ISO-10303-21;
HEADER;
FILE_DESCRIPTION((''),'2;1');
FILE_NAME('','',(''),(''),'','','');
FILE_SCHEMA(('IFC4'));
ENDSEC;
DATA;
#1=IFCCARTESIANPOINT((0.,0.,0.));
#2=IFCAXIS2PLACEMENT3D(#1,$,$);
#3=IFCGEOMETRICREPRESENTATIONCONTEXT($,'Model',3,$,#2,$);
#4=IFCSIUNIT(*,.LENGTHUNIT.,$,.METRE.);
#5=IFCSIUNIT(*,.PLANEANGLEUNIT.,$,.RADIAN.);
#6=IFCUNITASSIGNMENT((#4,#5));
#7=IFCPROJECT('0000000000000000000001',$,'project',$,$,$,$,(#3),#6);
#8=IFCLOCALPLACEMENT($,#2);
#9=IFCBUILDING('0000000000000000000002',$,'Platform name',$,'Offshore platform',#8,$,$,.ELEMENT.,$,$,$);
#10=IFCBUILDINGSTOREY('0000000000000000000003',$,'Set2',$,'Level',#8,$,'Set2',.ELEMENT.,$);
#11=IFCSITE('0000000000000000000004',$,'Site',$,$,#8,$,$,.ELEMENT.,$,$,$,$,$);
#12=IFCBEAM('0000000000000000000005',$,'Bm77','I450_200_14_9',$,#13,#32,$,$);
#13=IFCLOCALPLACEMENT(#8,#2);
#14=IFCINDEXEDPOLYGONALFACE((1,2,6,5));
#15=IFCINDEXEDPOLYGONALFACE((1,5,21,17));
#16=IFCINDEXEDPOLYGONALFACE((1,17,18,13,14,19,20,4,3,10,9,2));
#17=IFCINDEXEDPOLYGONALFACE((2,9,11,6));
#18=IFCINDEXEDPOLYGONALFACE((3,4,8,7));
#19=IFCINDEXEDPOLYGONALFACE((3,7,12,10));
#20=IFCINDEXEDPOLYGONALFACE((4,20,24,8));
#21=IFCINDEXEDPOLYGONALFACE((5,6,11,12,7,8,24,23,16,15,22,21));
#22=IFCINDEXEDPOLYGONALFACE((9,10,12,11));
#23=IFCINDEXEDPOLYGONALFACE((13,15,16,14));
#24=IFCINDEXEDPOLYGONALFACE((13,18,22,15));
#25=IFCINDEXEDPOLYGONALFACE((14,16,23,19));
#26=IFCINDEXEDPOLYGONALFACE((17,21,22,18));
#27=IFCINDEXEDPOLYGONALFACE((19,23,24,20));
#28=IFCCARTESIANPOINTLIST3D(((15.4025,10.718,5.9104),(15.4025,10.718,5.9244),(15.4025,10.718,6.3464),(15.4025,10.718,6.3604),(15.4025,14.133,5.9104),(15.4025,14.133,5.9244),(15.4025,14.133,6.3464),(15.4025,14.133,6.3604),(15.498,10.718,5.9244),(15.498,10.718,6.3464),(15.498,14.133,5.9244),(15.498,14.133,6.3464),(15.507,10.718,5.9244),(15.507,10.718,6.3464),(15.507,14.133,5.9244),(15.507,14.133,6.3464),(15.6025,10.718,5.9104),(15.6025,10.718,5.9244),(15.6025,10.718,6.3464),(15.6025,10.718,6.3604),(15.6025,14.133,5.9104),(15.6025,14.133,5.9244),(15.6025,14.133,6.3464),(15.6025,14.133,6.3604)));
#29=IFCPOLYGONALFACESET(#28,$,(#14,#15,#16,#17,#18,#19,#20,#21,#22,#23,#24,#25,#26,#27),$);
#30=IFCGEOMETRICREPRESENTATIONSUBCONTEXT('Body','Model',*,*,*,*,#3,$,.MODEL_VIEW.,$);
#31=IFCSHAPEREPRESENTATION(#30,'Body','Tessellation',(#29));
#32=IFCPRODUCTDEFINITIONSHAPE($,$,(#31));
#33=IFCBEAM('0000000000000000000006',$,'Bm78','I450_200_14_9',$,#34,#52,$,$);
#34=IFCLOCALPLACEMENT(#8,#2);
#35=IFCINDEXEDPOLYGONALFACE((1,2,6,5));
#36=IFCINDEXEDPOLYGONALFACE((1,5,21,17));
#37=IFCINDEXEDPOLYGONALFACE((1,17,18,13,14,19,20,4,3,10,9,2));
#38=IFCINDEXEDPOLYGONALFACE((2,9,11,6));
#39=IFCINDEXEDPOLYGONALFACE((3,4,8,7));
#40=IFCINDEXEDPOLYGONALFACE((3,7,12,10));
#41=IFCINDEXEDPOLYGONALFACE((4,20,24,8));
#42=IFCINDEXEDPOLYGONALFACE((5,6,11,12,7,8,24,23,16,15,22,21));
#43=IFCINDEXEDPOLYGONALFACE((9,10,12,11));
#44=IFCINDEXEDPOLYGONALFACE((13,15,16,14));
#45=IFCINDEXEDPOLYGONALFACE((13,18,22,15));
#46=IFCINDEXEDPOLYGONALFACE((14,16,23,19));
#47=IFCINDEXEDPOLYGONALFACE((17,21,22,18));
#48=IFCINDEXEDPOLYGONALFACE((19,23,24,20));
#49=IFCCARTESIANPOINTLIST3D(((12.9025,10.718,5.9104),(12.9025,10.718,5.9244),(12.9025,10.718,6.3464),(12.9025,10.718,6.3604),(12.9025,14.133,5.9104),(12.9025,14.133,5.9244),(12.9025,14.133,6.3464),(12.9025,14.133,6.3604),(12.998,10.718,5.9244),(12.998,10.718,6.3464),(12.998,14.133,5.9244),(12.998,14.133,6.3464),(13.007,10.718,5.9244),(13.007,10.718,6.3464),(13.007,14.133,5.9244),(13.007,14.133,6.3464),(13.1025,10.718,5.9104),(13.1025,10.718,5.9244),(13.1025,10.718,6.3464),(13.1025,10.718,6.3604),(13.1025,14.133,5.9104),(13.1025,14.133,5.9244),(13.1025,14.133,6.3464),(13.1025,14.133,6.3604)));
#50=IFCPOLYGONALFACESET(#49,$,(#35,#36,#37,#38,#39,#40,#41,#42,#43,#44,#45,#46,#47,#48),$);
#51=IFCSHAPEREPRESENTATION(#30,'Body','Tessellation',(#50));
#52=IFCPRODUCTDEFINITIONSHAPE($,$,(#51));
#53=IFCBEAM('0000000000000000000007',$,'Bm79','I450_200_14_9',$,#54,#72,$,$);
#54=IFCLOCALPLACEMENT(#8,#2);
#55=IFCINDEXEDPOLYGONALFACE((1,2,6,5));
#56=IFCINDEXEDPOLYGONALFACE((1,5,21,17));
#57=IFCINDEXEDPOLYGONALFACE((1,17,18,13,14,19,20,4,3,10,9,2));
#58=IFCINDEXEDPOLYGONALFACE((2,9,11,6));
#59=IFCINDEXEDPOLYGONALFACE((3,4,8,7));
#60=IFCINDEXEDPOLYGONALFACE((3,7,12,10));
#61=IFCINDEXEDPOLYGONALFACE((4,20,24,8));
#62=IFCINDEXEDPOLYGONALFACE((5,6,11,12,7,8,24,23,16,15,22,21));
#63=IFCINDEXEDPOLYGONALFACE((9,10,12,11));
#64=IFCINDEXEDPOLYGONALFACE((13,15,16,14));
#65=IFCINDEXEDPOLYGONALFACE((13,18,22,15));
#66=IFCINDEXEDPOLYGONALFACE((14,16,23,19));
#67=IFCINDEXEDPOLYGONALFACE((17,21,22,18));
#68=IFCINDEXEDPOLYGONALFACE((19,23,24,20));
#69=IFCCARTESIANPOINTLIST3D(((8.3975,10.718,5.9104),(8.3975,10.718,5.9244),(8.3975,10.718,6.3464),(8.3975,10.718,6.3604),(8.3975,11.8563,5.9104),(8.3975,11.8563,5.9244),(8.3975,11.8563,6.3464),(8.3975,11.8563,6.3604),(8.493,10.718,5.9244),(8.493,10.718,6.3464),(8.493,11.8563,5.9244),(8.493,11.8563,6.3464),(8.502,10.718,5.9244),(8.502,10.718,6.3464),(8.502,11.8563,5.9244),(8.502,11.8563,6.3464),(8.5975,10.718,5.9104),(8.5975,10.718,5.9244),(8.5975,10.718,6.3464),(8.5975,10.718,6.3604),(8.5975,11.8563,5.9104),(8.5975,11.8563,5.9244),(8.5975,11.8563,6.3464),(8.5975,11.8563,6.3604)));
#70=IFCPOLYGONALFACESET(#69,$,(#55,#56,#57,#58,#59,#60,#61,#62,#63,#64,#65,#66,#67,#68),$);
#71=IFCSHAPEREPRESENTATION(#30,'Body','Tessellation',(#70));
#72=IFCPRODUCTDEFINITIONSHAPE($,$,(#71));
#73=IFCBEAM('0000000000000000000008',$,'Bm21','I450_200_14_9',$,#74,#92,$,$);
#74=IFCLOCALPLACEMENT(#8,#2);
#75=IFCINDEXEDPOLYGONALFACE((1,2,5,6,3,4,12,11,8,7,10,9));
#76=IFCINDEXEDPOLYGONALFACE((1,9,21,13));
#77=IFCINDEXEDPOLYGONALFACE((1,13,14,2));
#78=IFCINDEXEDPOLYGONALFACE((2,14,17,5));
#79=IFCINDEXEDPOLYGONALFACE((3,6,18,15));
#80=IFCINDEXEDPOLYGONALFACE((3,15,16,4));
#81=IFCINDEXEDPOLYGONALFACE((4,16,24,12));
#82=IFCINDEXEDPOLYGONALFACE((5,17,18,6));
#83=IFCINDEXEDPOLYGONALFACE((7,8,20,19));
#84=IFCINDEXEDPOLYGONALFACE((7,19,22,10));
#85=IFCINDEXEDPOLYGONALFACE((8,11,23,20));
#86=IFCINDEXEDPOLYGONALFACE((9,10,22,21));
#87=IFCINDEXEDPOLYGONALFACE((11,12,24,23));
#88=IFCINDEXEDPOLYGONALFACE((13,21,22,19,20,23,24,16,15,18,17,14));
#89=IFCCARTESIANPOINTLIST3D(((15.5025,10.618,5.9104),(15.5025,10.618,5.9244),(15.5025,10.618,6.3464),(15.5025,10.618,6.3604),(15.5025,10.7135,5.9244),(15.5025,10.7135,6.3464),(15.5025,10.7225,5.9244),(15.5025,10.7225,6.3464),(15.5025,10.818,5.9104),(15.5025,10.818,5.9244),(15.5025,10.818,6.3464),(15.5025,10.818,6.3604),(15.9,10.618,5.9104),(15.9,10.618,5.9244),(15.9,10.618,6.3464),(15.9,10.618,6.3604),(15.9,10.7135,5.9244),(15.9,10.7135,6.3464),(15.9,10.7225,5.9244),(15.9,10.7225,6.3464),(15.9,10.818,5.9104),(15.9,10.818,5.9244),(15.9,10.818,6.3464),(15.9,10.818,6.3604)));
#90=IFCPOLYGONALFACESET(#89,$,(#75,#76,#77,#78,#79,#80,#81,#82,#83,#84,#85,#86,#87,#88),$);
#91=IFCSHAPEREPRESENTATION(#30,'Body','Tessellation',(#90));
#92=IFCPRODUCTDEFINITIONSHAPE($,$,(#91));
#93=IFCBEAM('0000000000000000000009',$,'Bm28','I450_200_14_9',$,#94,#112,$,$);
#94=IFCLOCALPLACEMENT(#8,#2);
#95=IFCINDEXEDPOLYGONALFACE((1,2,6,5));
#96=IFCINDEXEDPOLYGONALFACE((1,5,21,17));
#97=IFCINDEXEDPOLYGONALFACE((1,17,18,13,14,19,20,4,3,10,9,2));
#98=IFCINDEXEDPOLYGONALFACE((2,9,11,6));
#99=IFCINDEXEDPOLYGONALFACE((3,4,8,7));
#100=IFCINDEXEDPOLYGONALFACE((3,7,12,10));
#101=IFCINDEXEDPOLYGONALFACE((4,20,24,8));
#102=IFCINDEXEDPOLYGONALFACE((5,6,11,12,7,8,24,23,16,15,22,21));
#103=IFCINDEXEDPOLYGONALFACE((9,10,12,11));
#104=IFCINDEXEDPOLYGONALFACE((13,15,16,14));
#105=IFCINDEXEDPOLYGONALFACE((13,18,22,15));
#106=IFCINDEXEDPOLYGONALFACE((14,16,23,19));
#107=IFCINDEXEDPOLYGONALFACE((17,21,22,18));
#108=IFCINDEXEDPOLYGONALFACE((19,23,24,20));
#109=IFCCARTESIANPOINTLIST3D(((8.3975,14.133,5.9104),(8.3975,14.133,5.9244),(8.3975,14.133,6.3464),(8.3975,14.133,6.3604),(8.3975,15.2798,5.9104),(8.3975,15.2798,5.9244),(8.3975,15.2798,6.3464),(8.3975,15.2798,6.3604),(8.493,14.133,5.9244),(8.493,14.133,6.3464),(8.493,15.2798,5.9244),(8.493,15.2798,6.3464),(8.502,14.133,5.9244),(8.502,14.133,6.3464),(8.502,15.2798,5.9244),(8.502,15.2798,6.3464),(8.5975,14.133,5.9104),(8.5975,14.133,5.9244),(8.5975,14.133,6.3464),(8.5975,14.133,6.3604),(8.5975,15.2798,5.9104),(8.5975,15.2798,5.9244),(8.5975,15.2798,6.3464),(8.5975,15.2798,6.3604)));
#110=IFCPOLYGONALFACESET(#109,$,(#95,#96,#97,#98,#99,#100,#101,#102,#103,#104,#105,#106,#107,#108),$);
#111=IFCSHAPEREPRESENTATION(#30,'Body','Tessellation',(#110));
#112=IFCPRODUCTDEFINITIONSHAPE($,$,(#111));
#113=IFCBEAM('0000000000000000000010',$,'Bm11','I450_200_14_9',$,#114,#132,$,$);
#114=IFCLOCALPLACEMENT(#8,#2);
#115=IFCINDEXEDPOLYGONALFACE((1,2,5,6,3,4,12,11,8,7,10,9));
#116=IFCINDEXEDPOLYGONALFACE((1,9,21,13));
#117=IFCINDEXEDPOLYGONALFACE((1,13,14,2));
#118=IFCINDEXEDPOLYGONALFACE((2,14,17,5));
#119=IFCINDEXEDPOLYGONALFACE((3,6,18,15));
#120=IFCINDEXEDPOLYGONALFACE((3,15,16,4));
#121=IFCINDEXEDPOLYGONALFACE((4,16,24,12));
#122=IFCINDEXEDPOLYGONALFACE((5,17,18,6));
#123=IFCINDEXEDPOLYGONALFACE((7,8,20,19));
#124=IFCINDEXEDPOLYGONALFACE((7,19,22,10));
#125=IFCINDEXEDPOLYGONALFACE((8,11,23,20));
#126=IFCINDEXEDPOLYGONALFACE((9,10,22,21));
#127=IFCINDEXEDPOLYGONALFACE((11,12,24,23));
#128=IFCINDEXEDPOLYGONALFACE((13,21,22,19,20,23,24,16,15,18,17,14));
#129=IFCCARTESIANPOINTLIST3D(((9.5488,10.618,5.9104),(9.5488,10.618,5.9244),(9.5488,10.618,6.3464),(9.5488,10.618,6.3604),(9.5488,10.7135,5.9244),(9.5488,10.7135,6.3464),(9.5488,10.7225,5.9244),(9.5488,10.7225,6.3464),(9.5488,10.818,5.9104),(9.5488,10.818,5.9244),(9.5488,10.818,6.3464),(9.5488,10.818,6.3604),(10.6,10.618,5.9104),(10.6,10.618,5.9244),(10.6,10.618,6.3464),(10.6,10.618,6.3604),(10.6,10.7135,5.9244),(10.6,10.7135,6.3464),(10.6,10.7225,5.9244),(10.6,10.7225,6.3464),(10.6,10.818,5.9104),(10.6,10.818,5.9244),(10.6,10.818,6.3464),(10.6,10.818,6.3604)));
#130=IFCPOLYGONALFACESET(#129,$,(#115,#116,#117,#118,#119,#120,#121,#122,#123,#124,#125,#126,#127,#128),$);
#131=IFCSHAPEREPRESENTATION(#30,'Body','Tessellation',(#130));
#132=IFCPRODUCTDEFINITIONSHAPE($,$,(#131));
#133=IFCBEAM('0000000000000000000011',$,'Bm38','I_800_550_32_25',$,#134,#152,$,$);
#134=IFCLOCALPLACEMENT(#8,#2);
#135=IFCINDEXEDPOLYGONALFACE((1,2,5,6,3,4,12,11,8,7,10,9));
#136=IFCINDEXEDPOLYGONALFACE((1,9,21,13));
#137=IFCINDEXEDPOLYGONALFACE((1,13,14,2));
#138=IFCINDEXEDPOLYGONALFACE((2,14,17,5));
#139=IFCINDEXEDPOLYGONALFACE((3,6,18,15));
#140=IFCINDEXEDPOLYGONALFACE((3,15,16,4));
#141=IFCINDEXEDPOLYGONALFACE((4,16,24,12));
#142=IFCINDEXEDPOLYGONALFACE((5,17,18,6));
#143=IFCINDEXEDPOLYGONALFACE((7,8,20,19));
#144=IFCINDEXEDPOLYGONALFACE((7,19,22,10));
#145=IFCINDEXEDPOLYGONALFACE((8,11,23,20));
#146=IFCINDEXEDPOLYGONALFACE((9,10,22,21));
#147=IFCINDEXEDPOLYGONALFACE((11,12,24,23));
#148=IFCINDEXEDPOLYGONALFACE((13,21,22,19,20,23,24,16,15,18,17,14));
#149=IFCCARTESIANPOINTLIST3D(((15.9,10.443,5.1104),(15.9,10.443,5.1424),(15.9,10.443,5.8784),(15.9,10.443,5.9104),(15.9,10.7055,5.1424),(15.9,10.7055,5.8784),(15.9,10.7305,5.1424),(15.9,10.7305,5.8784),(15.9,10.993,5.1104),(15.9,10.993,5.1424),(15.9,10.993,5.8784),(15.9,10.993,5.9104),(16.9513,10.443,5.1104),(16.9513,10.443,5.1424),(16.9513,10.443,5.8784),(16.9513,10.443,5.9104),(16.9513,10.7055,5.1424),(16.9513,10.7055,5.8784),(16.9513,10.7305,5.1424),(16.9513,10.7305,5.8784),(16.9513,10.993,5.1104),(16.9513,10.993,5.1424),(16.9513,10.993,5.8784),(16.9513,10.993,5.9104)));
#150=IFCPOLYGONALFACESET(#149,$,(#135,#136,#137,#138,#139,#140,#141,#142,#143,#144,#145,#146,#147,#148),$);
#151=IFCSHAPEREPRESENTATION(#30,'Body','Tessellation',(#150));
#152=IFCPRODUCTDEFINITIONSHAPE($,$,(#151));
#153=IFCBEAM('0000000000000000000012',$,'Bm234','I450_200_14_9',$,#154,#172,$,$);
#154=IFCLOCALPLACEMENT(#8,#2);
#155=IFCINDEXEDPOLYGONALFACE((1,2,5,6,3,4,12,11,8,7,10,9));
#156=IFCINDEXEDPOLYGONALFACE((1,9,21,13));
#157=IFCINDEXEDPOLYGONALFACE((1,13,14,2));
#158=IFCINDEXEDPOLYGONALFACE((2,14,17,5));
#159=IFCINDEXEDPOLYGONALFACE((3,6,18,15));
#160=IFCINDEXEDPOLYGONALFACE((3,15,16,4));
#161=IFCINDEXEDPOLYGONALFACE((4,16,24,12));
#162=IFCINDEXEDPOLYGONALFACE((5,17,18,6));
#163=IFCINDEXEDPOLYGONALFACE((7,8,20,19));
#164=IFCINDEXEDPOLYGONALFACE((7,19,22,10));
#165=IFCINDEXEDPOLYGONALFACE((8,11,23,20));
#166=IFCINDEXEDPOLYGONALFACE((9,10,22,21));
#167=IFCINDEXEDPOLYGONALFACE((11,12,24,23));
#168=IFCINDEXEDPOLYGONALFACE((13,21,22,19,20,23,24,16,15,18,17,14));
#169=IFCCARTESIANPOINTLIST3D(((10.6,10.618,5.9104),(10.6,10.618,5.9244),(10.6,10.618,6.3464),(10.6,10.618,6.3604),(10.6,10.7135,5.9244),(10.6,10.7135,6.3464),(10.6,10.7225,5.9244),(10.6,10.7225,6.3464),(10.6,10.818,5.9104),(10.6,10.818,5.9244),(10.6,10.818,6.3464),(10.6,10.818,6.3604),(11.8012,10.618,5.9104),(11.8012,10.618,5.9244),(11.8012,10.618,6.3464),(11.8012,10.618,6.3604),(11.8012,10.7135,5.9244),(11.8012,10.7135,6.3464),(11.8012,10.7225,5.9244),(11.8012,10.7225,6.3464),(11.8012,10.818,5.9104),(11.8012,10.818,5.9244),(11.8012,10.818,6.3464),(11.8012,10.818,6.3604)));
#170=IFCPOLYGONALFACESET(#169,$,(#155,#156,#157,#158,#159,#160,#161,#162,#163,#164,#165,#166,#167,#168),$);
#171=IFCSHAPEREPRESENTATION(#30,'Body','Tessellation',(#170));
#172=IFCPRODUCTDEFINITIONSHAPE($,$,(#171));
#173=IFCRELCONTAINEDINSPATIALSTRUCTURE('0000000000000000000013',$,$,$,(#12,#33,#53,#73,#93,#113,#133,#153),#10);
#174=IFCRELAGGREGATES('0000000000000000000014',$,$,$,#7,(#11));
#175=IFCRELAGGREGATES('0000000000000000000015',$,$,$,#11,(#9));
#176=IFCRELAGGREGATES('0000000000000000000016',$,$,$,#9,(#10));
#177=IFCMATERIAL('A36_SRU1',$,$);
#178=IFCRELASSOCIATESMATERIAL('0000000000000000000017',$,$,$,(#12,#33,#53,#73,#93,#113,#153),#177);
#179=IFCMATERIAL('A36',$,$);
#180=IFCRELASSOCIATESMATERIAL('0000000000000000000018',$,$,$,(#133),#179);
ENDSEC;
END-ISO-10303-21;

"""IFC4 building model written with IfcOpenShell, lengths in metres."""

from ifc_helpers import new_model, si_unit, frame, origin, origin_2d, place, context, subcontext, project, spatial, i_section, extrude, source, transform, mapped, material, element, save


model = new_model("IFC4")

# Units and contexts
model_context = context("Model", 3, world=origin())
body_context = subcontext(model_context, "Body", "Model", "MODEL_VIEW")
ifc_project = project(units=[si_unit("LENGTHUNIT", "METRE"), si_unit("PLANEANGLEUNIT", "RADIAN")], contexts=[model_context])

# Site, building, storey
placement_1 = place(None, origin())
site = spatial("IfcSite", under=ifc_project, at=placement_1, Name="Site", CompositionType="ELEMENT")
building = spatial("IfcBuilding", under=site, at=placement_1, Name="Platform name", ObjectType="Offshore platform", CompositionType="ELEMENT")
storey = spatial("IfcBuildingStorey", under=building, at=placement_1, Name="Set2", ObjectType="Level", LongName="Set2", CompositionType="ELEMENT")

# Beams
ifc_material_1 = material(Name="A36_SRU1")
shared_shape_1 = source(origin(), body_context, "Body", "SweptSolid", [
    extrude(i_section(OverallWidth=0.2, OverallDepth=0.45, WebThickness=0.009, FlangeThickness=0.014, FilletRadius=0.0, at=origin_2d()), frame((0.0, 0.0, 0.0), z_axis=(0.0, 1.0, 0.0), x_axis=(-1.0, 0.0, 0.0)), (0.0, 0.0, 1.0), 3.415),
])
placement_2 = place(None, origin())
placement_3 = place(placement_2, origin())
placement_4 = place(placement_3, origin())
beam_1_placement = place(placement_4, frame((15.5025, 10.718, 6.1354)))
element("IfcBeam", 1, at=beam_1_placement, inside=storey, material=ifc_material_1, Name="Bm77", Description="I450_200_14_9", context=body_context, shape_type="MappedRepresentation", body=[
    mapped(shared_shape_1, transform((0.0, 0.0, 0.0), scale=1.0)),
])
shared_shape_2 = source(origin(), body_context, "Body", "SweptSolid", [
    extrude(i_section(OverallWidth=0.2, OverallDepth=0.45, WebThickness=0.009, FlangeThickness=0.014, FilletRadius=0.0, at=origin_2d()), frame((0.0, 0.0, 0.0), z_axis=(0.0, 1.0, 0.0), x_axis=(-1.0, 0.0, 0.0)), (0.0, 0.0, 1.0), 3.415),
])
placement_5 = place(None, origin())
placement_6 = place(placement_5, origin())
placement_7 = place(placement_6, origin())
beam_2_placement = place(placement_7, frame((13.0025, 10.718, 6.1354)))
element("IfcBeam", 2, at=beam_2_placement, inside=storey, material=ifc_material_1, Name="Bm78", Description="I450_200_14_9", context=body_context, shape_type="MappedRepresentation", body=[
    mapped(shared_shape_2, transform((0.0, 0.0, 0.0), scale=1.0)),
])
shared_shape_3 = source(origin(), body_context, "Body", "SweptSolid", [
    extrude(i_section(OverallWidth=0.2, OverallDepth=0.45, WebThickness=0.009, FlangeThickness=0.014, FilletRadius=0.0, at=origin_2d()), frame((0.0, 0.0, 0.0), z_axis=(0.0, 1.0, 0.0), x_axis=(-1.0, 0.0, 0.0)), (0.0, 0.0, 1.0), 1.1383),
])
placement_8 = place(None, origin())
placement_9 = place(placement_8, origin())
placement_10 = place(placement_9, origin())
beam_3_placement = place(placement_10, frame((8.4975, 10.718, 6.1354)))
element("IfcBeam", 3, at=beam_3_placement, inside=storey, material=ifc_material_1, Name="Bm79", Description="I450_200_14_9", context=body_context, shape_type="MappedRepresentation", body=[
    mapped(shared_shape_3, transform((0.0, 0.0, 0.0), scale=1.0)),
])
shared_shape_4 = source(origin(), body_context, "Body", "SweptSolid", [
    extrude(i_section(OverallWidth=0.2, OverallDepth=0.45, WebThickness=0.009, FlangeThickness=0.014, FilletRadius=0.0, at=origin_2d()), frame((0.0, 0.0, 0.0), z_axis=(-1.0, 0.0, 0.0), x_axis=(0.0, -1.0, 0.0)), (0.0, 0.0, 1.0), 0.3975),
])
placement_11 = place(None, origin())
placement_12 = place(placement_11, origin())
placement_13 = place(placement_12, origin())
beam_4_placement = place(placement_13, frame((15.9, 10.718, 6.1354)))
element("IfcBeam", 4, at=beam_4_placement, inside=storey, material=ifc_material_1, Name="Bm21", Description="I450_200_14_9", context=body_context, shape_type="MappedRepresentation", body=[
    mapped(shared_shape_4, transform((0.0, 0.0, 0.0), scale=1.0)),
])
shared_shape_5 = source(origin(), body_context, "Body", "SweptSolid", [
    extrude(i_section(OverallWidth=0.2, OverallDepth=0.45, WebThickness=0.009, FlangeThickness=0.014, FilletRadius=0.0, at=origin_2d()), frame((0.0, 0.0, 0.0), z_axis=(0.0, 1.0, 0.0), x_axis=(-1.0, 0.0, 0.0)), (0.0, 0.0, 1.0), 1.1467),
])
placement_14 = place(None, origin())
placement_15 = place(placement_14, origin())
placement_16 = place(placement_15, origin())
beam_5_placement = place(placement_16, frame((8.4975, 14.133, 6.1354)))
element("IfcBeam", 5, at=beam_5_placement, inside=storey, material=ifc_material_1, Name="Bm28", Description="I450_200_14_9", context=body_context, shape_type="MappedRepresentation", body=[
    mapped(shared_shape_5, transform((0.0, 0.0, 0.0), scale=1.0)),
])
shared_shape_6 = source(origin(), body_context, "Body", "SweptSolid", [
    extrude(i_section(OverallWidth=0.2, OverallDepth=0.45, WebThickness=0.009, FlangeThickness=0.014, FilletRadius=0.0, at=origin_2d()), frame((0.0, 0.0, 0.0), z_axis=(-1.0, 0.0, 0.0), x_axis=(0.0, -1.0, 0.0)), (0.0, 0.0, 1.0), 1.0513),
])
placement_17 = place(None, origin())
placement_18 = place(placement_17, origin())
placement_19 = place(placement_18, origin())
beam_6_placement = place(placement_19, frame((10.6, 10.718, 6.1354)))
element("IfcBeam", 6, at=beam_6_placement, inside=storey, material=ifc_material_1, Name="Bm11", Description="I450_200_14_9", context=body_context, shape_type="MappedRepresentation", body=[
    mapped(shared_shape_6, transform((0.0, 0.0, 0.0), scale=1.0)),
])
ifc_material_2 = material(Name="A36")
shared_shape_7 = source(origin(), body_context, "Body", "SweptSolid", [
    extrude(i_section(OverallWidth=0.55, OverallDepth=0.8, WebThickness=0.025, FlangeThickness=0.032, FilletRadius=0.0, at=origin_2d()), frame((0.0, 0.0, 0.0), z_axis=(1.0, 0.0, 0.0), x_axis=(0.0, 1.0, 0.0)), (0.0, 0.0, 1.0), 1.0513),
])
placement_20 = place(None, origin())
placement_21 = place(placement_20, origin())
placement_22 = place(placement_21, origin())
beam_7_placement = place(placement_22, frame((15.9, 10.718, 5.5104)))
element("IfcBeam", 7, at=beam_7_placement, inside=storey, material=ifc_material_2, Name="Bm38", Description="I_800_550_32_25", context=body_context, shape_type="MappedRepresentation", body=[
    mapped(shared_shape_7, transform((0.0, 0.0, 0.0), scale=1.0)),
])
shared_shape_8 = source(origin(), body_context, "Body", "SweptSolid", [
    extrude(i_section(OverallWidth=0.2, OverallDepth=0.45, WebThickness=0.009, FlangeThickness=0.014, FilletRadius=0.0, at=origin_2d()), frame((0.0, 0.0, 0.0), z_axis=(-1.0, 0.0, 0.0), x_axis=(0.0, -1.0, 0.0)), (0.0, 0.0, 1.0), 1.2012),
])
placement_23 = place(None, origin())
placement_24 = place(placement_23, origin())
placement_25 = place(placement_24, origin())
beam_8_placement = place(placement_25, frame((11.8012, 10.718, 6.1354)))
element("IfcBeam", 8, at=beam_8_placement, inside=storey, material=ifc_material_1, Name="Bm234", Description="I450_200_14_9", context=body_context, shape_type="MappedRepresentation", body=[
    mapped(shared_shape_8, transform((0.0, 0.0, 0.0), scale=1.0)),
])

save(model, "model.ifc")
